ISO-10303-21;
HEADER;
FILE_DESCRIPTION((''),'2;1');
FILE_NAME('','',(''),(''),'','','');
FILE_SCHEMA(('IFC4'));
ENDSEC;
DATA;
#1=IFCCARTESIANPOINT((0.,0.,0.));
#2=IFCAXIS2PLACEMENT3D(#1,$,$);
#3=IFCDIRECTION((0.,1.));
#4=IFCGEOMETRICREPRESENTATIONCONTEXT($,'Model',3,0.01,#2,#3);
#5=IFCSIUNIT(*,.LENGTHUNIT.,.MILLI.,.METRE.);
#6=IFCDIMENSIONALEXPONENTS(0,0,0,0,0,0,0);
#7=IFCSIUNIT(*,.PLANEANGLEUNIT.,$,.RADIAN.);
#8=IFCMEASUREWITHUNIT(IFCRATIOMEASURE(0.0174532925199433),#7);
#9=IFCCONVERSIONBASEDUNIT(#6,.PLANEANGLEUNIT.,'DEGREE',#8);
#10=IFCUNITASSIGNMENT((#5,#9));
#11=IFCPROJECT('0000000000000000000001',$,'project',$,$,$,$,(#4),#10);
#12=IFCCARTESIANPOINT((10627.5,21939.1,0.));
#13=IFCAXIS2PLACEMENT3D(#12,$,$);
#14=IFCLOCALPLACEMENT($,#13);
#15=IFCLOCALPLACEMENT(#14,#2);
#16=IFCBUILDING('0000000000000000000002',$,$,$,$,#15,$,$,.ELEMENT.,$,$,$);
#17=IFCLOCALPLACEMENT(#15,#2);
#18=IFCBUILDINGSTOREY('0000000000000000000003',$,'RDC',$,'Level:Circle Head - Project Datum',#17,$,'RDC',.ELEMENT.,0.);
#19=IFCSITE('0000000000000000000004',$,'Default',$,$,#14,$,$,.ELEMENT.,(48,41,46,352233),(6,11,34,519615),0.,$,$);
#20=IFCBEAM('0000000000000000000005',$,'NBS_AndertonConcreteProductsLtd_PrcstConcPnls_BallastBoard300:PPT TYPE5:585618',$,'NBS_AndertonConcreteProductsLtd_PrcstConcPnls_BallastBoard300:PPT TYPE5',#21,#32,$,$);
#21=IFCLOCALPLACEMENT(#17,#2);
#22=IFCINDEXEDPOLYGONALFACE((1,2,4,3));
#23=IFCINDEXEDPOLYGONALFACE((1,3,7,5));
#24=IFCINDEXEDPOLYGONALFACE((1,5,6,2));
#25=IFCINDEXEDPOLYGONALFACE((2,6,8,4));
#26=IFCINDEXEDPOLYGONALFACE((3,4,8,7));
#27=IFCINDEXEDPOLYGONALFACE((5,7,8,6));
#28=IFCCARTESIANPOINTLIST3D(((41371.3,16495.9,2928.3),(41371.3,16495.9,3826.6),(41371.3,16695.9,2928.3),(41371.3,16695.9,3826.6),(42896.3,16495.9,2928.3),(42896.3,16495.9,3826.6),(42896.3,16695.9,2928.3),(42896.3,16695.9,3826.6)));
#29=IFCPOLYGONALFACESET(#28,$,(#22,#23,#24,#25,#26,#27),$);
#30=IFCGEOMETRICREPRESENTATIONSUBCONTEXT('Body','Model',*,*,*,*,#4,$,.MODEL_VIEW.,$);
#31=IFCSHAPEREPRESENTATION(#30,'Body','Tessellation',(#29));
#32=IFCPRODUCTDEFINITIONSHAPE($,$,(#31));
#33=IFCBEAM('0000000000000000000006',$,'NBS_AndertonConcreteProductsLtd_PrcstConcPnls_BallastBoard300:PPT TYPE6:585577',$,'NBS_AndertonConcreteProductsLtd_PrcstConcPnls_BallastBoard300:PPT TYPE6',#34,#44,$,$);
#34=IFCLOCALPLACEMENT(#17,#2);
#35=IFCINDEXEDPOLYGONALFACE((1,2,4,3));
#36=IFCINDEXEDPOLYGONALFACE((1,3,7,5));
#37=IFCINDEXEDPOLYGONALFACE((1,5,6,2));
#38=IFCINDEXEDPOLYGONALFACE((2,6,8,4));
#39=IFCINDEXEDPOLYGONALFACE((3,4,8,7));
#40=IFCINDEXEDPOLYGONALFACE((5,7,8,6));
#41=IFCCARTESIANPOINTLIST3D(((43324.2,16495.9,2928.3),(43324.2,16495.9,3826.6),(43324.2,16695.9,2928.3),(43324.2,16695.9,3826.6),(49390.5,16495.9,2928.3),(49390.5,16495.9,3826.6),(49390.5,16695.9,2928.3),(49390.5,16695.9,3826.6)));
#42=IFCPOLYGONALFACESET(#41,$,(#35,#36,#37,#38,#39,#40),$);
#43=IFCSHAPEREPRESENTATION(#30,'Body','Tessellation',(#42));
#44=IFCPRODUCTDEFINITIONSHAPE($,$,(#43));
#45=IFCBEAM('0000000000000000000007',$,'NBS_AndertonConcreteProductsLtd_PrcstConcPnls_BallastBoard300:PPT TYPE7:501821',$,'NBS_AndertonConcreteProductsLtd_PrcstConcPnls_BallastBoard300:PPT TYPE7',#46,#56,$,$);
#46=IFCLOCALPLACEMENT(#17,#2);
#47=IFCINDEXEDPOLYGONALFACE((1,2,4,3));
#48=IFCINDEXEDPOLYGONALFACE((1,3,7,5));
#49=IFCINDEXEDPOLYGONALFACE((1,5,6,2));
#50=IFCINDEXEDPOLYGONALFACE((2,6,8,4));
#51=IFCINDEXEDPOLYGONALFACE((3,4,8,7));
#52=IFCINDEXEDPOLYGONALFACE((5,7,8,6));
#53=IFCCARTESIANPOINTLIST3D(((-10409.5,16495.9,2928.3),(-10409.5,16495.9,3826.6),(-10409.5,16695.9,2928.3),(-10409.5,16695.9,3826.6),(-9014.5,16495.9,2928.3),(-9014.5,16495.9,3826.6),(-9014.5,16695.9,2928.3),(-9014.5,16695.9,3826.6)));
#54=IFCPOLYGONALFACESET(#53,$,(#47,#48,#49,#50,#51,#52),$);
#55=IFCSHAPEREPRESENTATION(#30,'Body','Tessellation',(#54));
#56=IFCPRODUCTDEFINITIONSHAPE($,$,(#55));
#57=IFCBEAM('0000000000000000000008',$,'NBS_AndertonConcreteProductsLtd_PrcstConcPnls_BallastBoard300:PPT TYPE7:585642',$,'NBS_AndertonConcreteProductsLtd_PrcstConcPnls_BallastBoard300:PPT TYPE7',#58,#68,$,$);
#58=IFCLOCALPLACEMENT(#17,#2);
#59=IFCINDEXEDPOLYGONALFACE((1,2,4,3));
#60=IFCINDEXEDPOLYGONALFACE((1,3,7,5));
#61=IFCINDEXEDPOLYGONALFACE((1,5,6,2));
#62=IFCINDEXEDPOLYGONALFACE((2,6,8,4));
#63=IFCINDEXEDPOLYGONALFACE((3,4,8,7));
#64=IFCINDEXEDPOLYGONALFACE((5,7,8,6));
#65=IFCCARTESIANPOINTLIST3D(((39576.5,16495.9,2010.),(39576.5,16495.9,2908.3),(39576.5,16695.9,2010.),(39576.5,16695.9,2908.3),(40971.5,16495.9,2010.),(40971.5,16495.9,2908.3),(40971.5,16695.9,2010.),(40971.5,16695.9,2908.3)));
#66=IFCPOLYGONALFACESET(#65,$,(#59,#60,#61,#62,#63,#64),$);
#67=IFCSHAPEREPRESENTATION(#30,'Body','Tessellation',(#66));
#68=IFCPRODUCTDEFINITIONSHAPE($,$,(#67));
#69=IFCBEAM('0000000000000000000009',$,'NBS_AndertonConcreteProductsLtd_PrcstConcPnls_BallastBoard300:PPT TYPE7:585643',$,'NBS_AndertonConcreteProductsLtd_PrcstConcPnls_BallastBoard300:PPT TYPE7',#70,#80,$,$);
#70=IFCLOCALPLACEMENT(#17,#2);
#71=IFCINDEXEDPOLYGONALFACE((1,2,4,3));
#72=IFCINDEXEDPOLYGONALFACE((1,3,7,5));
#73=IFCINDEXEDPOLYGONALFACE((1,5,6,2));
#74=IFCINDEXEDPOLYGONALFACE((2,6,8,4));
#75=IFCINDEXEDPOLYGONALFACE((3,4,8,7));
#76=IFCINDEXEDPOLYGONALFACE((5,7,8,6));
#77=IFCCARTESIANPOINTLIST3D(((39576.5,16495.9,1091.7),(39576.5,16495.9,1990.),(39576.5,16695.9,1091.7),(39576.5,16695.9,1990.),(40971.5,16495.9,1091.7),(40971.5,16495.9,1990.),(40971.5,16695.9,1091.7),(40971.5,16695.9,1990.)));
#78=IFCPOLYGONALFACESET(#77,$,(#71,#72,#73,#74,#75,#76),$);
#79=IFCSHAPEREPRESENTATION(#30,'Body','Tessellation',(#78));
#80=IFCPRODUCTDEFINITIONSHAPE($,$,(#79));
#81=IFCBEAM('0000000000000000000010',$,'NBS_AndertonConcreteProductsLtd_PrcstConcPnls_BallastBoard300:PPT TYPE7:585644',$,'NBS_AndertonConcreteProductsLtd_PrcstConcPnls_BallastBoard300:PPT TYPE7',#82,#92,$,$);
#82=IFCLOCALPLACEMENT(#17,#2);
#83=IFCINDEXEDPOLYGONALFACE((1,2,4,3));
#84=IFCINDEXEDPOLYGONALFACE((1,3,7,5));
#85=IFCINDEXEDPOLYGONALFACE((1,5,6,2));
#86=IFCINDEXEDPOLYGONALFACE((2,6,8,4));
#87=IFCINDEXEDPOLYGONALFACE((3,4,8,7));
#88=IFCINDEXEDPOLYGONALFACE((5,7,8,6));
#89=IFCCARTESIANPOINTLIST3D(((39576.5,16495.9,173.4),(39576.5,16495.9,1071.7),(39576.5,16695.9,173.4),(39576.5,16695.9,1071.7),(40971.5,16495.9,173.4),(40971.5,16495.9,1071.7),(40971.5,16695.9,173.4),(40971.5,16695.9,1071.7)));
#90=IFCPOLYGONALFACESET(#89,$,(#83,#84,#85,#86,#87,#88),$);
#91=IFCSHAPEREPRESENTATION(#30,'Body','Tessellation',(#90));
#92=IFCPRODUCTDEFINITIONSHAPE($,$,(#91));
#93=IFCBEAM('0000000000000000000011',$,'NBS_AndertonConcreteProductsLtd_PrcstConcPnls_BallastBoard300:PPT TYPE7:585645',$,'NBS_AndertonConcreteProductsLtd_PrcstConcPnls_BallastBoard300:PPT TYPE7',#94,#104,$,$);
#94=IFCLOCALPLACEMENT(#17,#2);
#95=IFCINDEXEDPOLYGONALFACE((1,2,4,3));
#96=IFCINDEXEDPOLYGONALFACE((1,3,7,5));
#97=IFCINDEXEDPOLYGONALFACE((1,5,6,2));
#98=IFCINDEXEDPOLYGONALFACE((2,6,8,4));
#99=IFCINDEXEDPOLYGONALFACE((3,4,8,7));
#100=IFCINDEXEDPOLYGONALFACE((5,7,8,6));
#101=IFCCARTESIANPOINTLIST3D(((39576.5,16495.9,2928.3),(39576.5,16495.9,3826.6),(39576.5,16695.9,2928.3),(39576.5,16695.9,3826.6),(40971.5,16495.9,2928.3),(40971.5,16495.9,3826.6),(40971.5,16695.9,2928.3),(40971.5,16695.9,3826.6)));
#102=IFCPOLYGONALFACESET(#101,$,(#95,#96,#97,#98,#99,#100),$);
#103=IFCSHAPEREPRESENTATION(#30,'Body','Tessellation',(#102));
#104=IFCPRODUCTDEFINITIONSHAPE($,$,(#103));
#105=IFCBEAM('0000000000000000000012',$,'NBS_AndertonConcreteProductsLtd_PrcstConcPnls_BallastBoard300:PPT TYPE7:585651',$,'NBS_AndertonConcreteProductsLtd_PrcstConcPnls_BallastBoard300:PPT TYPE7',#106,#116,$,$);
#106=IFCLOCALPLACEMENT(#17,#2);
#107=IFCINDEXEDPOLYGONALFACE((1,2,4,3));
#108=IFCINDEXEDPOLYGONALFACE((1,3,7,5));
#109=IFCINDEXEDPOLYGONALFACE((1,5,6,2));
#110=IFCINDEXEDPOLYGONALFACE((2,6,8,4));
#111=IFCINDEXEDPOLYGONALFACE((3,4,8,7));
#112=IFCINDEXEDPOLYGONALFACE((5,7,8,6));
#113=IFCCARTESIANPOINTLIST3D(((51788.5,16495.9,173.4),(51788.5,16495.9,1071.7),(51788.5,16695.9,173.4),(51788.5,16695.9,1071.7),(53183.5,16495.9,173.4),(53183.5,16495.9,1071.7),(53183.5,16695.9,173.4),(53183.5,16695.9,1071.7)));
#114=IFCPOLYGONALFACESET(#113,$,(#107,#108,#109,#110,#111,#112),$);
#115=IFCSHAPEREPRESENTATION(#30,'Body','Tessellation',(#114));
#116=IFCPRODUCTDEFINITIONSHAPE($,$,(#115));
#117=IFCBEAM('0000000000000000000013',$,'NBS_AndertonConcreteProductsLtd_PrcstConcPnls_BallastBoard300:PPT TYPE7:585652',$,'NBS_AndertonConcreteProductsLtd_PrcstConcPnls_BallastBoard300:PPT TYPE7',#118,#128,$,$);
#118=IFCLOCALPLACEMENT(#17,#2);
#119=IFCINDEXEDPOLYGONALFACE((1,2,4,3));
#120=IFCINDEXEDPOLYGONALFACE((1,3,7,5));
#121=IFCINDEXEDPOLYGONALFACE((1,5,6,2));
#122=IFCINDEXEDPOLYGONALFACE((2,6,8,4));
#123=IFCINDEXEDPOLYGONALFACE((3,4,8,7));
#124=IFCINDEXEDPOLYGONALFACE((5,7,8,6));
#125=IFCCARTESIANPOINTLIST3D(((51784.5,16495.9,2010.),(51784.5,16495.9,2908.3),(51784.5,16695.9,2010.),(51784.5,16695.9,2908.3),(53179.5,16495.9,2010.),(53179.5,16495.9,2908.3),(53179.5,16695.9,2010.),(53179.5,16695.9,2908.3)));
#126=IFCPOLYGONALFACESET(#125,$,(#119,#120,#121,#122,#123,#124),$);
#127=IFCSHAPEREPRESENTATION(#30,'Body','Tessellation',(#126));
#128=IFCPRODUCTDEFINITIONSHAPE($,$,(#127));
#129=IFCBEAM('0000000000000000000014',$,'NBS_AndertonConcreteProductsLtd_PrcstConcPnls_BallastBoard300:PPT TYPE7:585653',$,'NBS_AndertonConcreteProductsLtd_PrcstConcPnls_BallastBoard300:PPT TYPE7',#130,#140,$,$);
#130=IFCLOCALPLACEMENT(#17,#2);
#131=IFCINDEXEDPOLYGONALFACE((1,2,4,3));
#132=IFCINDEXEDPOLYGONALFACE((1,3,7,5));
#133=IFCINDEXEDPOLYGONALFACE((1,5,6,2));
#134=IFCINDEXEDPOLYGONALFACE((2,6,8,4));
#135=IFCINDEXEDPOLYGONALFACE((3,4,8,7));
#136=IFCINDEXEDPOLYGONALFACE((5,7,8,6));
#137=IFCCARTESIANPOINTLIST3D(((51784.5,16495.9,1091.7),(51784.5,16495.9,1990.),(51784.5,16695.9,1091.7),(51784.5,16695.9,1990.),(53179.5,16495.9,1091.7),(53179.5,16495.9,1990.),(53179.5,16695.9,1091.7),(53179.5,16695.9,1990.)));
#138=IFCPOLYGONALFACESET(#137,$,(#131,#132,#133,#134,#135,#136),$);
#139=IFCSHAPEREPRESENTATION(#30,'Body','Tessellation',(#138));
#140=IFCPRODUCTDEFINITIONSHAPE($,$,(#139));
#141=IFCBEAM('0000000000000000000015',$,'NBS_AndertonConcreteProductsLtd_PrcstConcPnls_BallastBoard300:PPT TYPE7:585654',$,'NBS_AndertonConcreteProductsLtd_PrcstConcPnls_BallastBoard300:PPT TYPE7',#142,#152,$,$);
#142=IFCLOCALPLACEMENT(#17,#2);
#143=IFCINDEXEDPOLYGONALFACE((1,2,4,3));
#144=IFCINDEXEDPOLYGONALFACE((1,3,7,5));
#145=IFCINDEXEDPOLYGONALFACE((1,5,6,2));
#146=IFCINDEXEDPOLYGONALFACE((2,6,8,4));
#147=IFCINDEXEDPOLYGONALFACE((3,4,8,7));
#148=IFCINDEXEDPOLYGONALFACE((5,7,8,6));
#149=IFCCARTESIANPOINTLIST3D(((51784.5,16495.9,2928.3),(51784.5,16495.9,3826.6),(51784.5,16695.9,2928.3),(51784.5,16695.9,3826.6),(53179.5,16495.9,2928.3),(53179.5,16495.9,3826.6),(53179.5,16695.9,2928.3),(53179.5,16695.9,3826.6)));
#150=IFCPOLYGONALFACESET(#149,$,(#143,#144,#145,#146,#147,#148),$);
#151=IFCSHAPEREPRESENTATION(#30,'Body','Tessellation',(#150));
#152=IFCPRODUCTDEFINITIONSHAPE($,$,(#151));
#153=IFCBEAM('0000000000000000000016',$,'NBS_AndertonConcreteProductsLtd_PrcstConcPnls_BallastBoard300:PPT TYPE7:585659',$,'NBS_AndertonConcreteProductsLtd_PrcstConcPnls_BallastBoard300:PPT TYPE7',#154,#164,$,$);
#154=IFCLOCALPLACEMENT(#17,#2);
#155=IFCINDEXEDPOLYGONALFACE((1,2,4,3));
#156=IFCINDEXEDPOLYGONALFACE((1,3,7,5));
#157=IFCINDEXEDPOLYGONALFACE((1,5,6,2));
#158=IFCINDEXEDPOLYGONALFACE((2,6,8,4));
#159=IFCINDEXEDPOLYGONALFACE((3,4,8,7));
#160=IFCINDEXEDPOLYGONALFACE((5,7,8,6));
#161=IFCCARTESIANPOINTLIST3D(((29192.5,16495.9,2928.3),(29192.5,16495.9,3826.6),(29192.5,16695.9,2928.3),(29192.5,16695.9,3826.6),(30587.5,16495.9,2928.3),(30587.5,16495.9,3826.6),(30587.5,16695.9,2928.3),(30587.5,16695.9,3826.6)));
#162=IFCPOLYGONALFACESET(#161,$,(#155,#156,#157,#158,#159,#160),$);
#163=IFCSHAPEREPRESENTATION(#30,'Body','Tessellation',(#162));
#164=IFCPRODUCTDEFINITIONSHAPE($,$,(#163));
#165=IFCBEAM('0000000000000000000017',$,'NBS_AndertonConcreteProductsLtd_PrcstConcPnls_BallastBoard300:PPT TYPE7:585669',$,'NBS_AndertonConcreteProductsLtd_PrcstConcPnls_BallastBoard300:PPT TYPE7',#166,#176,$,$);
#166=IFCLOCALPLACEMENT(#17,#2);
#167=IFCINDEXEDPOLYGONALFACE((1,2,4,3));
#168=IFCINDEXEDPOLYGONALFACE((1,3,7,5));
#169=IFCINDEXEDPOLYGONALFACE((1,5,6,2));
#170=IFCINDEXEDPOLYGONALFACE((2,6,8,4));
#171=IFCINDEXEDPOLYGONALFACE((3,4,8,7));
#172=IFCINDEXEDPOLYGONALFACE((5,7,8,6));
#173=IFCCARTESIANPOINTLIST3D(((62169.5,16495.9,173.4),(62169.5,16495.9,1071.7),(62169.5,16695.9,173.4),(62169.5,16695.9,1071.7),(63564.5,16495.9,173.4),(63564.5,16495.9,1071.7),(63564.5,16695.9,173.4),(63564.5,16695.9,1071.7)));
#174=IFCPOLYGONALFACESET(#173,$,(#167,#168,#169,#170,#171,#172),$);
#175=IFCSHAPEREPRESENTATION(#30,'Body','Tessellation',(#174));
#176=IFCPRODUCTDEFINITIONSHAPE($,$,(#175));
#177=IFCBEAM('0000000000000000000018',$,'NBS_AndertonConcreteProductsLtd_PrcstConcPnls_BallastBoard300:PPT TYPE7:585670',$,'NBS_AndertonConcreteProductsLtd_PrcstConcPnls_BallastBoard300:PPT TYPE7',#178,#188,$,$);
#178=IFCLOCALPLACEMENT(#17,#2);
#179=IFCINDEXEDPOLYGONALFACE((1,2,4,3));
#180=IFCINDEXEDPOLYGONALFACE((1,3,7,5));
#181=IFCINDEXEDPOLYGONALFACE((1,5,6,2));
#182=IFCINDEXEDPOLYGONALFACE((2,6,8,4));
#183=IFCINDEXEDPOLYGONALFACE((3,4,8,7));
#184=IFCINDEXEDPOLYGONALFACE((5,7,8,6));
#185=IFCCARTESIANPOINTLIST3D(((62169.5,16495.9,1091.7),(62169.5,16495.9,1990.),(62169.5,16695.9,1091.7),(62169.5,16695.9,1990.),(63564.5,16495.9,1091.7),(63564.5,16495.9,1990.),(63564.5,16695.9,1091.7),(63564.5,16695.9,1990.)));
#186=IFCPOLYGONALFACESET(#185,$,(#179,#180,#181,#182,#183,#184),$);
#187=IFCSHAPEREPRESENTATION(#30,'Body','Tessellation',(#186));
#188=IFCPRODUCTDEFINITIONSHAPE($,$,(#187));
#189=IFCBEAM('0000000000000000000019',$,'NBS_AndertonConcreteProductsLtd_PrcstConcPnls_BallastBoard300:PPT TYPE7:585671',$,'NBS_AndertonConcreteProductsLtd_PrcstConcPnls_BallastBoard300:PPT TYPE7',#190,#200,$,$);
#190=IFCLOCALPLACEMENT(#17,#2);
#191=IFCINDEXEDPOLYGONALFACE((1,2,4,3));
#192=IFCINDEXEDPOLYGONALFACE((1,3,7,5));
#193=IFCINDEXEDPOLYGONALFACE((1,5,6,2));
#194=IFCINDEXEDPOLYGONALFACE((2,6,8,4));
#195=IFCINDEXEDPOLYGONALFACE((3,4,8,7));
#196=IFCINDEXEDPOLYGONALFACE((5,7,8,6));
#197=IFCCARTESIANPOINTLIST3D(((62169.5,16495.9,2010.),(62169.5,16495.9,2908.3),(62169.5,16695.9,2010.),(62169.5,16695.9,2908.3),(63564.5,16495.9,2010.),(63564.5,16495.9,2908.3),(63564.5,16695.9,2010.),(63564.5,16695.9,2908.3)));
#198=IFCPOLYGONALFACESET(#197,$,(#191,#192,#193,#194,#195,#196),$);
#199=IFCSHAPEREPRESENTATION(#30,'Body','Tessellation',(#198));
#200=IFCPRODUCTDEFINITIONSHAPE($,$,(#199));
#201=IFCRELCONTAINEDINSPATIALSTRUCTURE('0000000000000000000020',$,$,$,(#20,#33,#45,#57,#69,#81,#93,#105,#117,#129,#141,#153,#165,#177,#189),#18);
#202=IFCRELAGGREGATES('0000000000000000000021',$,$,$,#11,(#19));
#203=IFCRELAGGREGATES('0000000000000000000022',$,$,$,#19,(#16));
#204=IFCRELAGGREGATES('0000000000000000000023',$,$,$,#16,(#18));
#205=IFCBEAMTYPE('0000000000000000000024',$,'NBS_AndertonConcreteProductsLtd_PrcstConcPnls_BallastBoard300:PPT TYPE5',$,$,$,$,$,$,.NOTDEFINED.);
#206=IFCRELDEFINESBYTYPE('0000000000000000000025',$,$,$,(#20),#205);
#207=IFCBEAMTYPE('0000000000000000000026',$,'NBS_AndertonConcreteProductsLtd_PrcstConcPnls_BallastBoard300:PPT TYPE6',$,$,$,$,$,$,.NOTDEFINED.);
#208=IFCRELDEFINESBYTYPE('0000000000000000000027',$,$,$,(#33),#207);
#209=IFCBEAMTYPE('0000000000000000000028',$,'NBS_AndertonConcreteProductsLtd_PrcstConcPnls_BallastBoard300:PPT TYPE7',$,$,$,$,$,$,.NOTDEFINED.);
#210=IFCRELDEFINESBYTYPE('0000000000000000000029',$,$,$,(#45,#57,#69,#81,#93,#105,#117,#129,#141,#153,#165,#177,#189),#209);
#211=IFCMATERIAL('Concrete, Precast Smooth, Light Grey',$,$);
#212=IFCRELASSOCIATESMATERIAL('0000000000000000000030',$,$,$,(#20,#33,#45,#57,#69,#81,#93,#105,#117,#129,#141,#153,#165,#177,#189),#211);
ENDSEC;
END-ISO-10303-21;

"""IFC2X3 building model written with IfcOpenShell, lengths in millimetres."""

from ifc_helpers import new_model, entity, si_unit, converted_unit, direction, frame, frame_2d, origin, place, context, subcontext, project, spatial, rectangle, extrude, material, type_object, element, save


model = new_model("IFC2X3")

# Units and contexts
model_context = context("Model", 3, precision=0.01, world=origin(), true_north=direction((0.0, 1.0)))
body_context = subcontext(model_context, "Body", "Model", "MODEL_VIEW")
ifc_project = project(units=[si_unit("LENGTHUNIT", "METRE", prefix="MILLI"), converted_unit("PLANEANGLEUNIT", "DEGREE", entity("IfcRatioMeasure", 0.0174532925199433), si_unit("PLANEANGLEUNIT", "RADIAN"), dimensions=[0, 0, 0, 0, 0, 0, 0])], contexts=[model_context])

# Site, building, storey
site_placement = place(None, frame((10627.5, 21939.1, 0.0)))
site = spatial("IfcSite", under=ifc_project, at=site_placement, Name="Default", CompositionType="ELEMENT", RefLatitude=(48, 41, 46, 352233), RefLongitude=(6, 11, 34, 519615), RefElevation=0.0)
building_placement = place(site_placement, origin())
building = spatial("IfcBuilding", under=site, at=building_placement, CompositionType="ELEMENT")
storey_placement = place(building_placement, origin())
storey = spatial("IfcBuildingStorey", under=building, at=storey_placement, Name="RDC", ObjectType="Level:Circle Head - Project Datum", LongName="RDC", CompositionType="ELEMENT", Elevation=0.0)

# Shared definitions
ifc_material = material(Name="Concrete, Precast Smooth, Light Grey")

# Beams
beam_type_1 = type_object("IfcBeamType", Name="NBS_AndertonConcreteProductsLtd_PrcstConcPnls_BallastBoard300:PPT TYPE5", PredefinedType="NOTDEFINED")
beam_1_placement = place(storey_placement, origin())
element("IfcBeam", 1, at=beam_1_placement, inside=storey, type_object=beam_type_1, material=ifc_material, Name="NBS_AndertonConcreteProductsLtd_PrcstConcPnls_BallastBoard300:PPT TYPE5:585618", ObjectType="NBS_AndertonConcreteProductsLtd_PrcstConcPnls_BallastBoard300:PPT TYPE5", context=body_context, shape_type="SweptSolid", body=[
    extrude(rectangle(XDim=898.3, YDim=200.0, at=frame_2d((0.0, 0.0), x_axis=(1.0, 0.0))), frame((41371.3, 16595.9, 3377.5), z_axis=(1.0, 0.0, 0.0), x_axis=(0.0, 0.0, -1.0)), (0.0, 0.0, 1.0), 1525.0),
])
beam_type_2 = type_object("IfcBeamType", Name="NBS_AndertonConcreteProductsLtd_PrcstConcPnls_BallastBoard300:PPT TYPE6", PredefinedType="NOTDEFINED")
beam_2_placement = place(storey_placement, origin())
element("IfcBeam", 2, at=beam_2_placement, inside=storey, type_object=beam_type_2, material=ifc_material, Name="NBS_AndertonConcreteProductsLtd_PrcstConcPnls_BallastBoard300:PPT TYPE6:585577", ObjectType="NBS_AndertonConcreteProductsLtd_PrcstConcPnls_BallastBoard300:PPT TYPE6", context=body_context, shape_type="SweptSolid", body=[
    extrude(rectangle(XDim=898.3, YDim=200.0, at=frame_2d((0.0, 0.0), x_axis=(1.0, 0.0))), frame((43324.2, 16595.9, 3377.5), z_axis=(1.0, 0.0, 0.0), x_axis=(0.0, 0.0, -1.0)), (0.0, 0.0, 1.0), 6066.3),
])
beam_type_3 = type_object("IfcBeamType", Name="NBS_AndertonConcreteProductsLtd_PrcstConcPnls_BallastBoard300:PPT TYPE7", PredefinedType="NOTDEFINED")
beam_3_placement = place(storey_placement, origin())
element("IfcBeam", 3, at=beam_3_placement, inside=storey, type_object=beam_type_3, material=ifc_material, Name="NBS_AndertonConcreteProductsLtd_PrcstConcPnls_BallastBoard300:PPT TYPE7:501821", ObjectType="NBS_AndertonConcreteProductsLtd_PrcstConcPnls_BallastBoard300:PPT TYPE7", context=body_context, shape_type="SweptSolid", body=[
    extrude(rectangle(XDim=898.3, YDim=200.0, at=frame_2d((0.0, 0.0), x_axis=(0.0, 1.0))), frame((-10409.5, 16595.9, 3377.4), z_axis=(1.0, 0.0, 0.0), x_axis=(0.0, 1.0, 0.0)), (0.0, 0.0, 1.0), 1395.0),
])
beam_4_placement = place(storey_placement, origin())
element("IfcBeam", 4, at=beam_4_placement, inside=storey, type_object=beam_type_3, material=ifc_material, Name="NBS_AndertonConcreteProductsLtd_PrcstConcPnls_BallastBoard300:PPT TYPE7:585642", ObjectType="NBS_AndertonConcreteProductsLtd_PrcstConcPnls_BallastBoard300:PPT TYPE7", context=body_context, shape_type="SweptSolid", body=[
    extrude(rectangle(XDim=898.3, YDim=200.0, at=frame_2d((0.0, 0.0), x_axis=(1.0, 0.0))), frame((39576.5, 16595.9, 2459.2), z_axis=(1.0, 0.0, 0.0), x_axis=(0.0, 0.0, -1.0)), (0.0, 0.0, 1.0), 1395.0),
])
beam_5_placement = place(storey_placement, origin())
element("IfcBeam", 5, at=beam_5_placement, inside=storey, type_object=beam_type_3, material=ifc_material, Name="NBS_AndertonConcreteProductsLtd_PrcstConcPnls_BallastBoard300:PPT TYPE7:585643", ObjectType="NBS_AndertonConcreteProductsLtd_PrcstConcPnls_BallastBoard300:PPT TYPE7", context=body_context, shape_type="SweptSolid", body=[
    extrude(rectangle(XDim=898.3, YDim=200.0, at=frame_2d((0.0, 0.0), x_axis=(1.0, 0.0))), frame((39576.5, 16595.9, 1540.8), z_axis=(1.0, 0.0, 0.0), x_axis=(0.0, 0.0, -1.0)), (0.0, 0.0, 1.0), 1395.0),
])
beam_6_placement = place(storey_placement, origin())
element("IfcBeam", 6, at=beam_6_placement, inside=storey, type_object=beam_type_3, material=ifc_material, Name="NBS_AndertonConcreteProductsLtd_PrcstConcPnls_BallastBoard300:PPT TYPE7:585644", ObjectType="NBS_AndertonConcreteProductsLtd_PrcstConcPnls_BallastBoard300:PPT TYPE7", context=body_context, shape_type="SweptSolid", body=[
    extrude(rectangle(XDim=898.3, YDim=200.0, at=frame_2d((0.0, 0.0), x_axis=(1.0, 0.0))), frame((39576.5, 16595.9, 622.5), z_axis=(1.0, 0.0, 0.0), x_axis=(0.0, 0.0, -1.0)), (0.0, 0.0, 1.0), 1395.0),
])
beam_7_placement = place(storey_placement, origin())
element("IfcBeam", 7, at=beam_7_placement, inside=storey, type_object=beam_type_3, material=ifc_material, Name="NBS_AndertonConcreteProductsLtd_PrcstConcPnls_BallastBoard300:PPT TYPE7:585645", ObjectType="NBS_AndertonConcreteProductsLtd_PrcstConcPnls_BallastBoard300:PPT TYPE7", context=body_context, shape_type="SweptSolid", body=[
    extrude(rectangle(XDim=898.3, YDim=200.0, at=frame_2d((0.0, 0.0), x_axis=(1.0, 0.0))), frame((39576.5, 16595.9, 3377.5), z_axis=(1.0, 0.0, 0.0), x_axis=(0.0, 0.0, -1.0)), (0.0, 0.0, 1.0), 1395.0),
])
beam_8_placement = place(storey_placement, origin())
element("IfcBeam", 8, at=beam_8_placement, inside=storey, type_object=beam_type_3, material=ifc_material, Name="NBS_AndertonConcreteProductsLtd_PrcstConcPnls_BallastBoard300:PPT TYPE7:585651", ObjectType="NBS_AndertonConcreteProductsLtd_PrcstConcPnls_BallastBoard300:PPT TYPE7", context=body_context, shape_type="SweptSolid", body=[
    extrude(rectangle(XDim=898.3, YDim=200.0, at=frame_2d((0.0, 0.0), x_axis=(1.0, 0.0))), frame((51788.5, 16595.9, 622.5), z_axis=(1.0, 0.0, 0.0), x_axis=(0.0, 0.0, -1.0)), (0.0, 0.0, 1.0), 1395.0),
])
beam_9_placement = place(storey_placement, origin())
element("IfcBeam", 9, at=beam_9_placement, inside=storey, type_object=beam_type_3, material=ifc_material, Name="NBS_AndertonConcreteProductsLtd_PrcstConcPnls_BallastBoard300:PPT TYPE7:585652", ObjectType="NBS_AndertonConcreteProductsLtd_PrcstConcPnls_BallastBoard300:PPT TYPE7", context=body_context, shape_type="SweptSolid", body=[
    extrude(rectangle(XDim=898.3, YDim=200.0, at=frame_2d((0.0, 0.0), x_axis=(1.0, 0.0))), frame((51784.5, 16595.9, 2459.2), z_axis=(1.0, 0.0, 0.0), x_axis=(0.0, 0.0, -1.0)), (0.0, 0.0, 1.0), 1395.0),
])
beam_10_placement = place(storey_placement, origin())
element("IfcBeam", 10, at=beam_10_placement, inside=storey, type_object=beam_type_3, material=ifc_material, Name="NBS_AndertonConcreteProductsLtd_PrcstConcPnls_BallastBoard300:PPT TYPE7:585653", ObjectType="NBS_AndertonConcreteProductsLtd_PrcstConcPnls_BallastBoard300:PPT TYPE7", context=body_context, shape_type="SweptSolid", body=[
    extrude(rectangle(XDim=898.3, YDim=200.0, at=frame_2d((0.0, 0.0), x_axis=(1.0, 0.0))), frame((51784.5, 16595.9, 1540.8), z_axis=(1.0, 0.0, 0.0), x_axis=(0.0, 0.0, -1.0)), (0.0, 0.0, 1.0), 1395.0),
])
beam_11_placement = place(storey_placement, origin())
element("IfcBeam", 11, at=beam_11_placement, inside=storey, type_object=beam_type_3, material=ifc_material, Name="NBS_AndertonConcreteProductsLtd_PrcstConcPnls_BallastBoard300:PPT TYPE7:585654", ObjectType="NBS_AndertonConcreteProductsLtd_PrcstConcPnls_BallastBoard300:PPT TYPE7", context=body_context, shape_type="SweptSolid", body=[
    extrude(rectangle(XDim=898.3, YDim=200.0, at=frame_2d((0.0, 0.0), x_axis=(1.0, 0.0))), frame((51784.5, 16595.9, 3377.5), z_axis=(1.0, 0.0, 0.0), x_axis=(0.0, 0.0, -1.0)), (0.0, 0.0, 1.0), 1395.0),
])
beam_12_placement = place(storey_placement, origin())
element("IfcBeam", 12, at=beam_12_placement, inside=storey, type_object=beam_type_3, material=ifc_material, Name="NBS_AndertonConcreteProductsLtd_PrcstConcPnls_BallastBoard300:PPT TYPE7:585659", ObjectType="NBS_AndertonConcreteProductsLtd_PrcstConcPnls_BallastBoard300:PPT TYPE7", context=body_context, shape_type="SweptSolid", body=[
    extrude(rectangle(XDim=898.3, YDim=200.0, at=frame_2d((0.0, 0.0), x_axis=(1.0, 0.0))), frame((29192.5, 16595.9, 3377.5), z_axis=(1.0, 0.0, 0.0), x_axis=(0.0, 0.0, -1.0)), (0.0, 0.0, 1.0), 1395.0),
])
beam_13_placement = place(storey_placement, origin())
element("IfcBeam", 13, at=beam_13_placement, inside=storey, type_object=beam_type_3, material=ifc_material, Name="NBS_AndertonConcreteProductsLtd_PrcstConcPnls_BallastBoard300:PPT TYPE7:585669", ObjectType="NBS_AndertonConcreteProductsLtd_PrcstConcPnls_BallastBoard300:PPT TYPE7", context=body_context, shape_type="SweptSolid", body=[
    extrude(rectangle(XDim=898.3, YDim=200.0, at=frame_2d((0.0, 0.0), x_axis=(1.0, 0.0))), frame((62169.5, 16595.9, 622.5), z_axis=(1.0, 0.0, 0.0), x_axis=(0.0, 0.0, -1.0)), (0.0, 0.0, 1.0), 1395.0),
])
beam_14_placement = place(storey_placement, origin())
element("IfcBeam", 14, at=beam_14_placement, inside=storey, type_object=beam_type_3, material=ifc_material, Name="NBS_AndertonConcreteProductsLtd_PrcstConcPnls_BallastBoard300:PPT TYPE7:585670", ObjectType="NBS_AndertonConcreteProductsLtd_PrcstConcPnls_BallastBoard300:PPT TYPE7", context=body_context, shape_type="SweptSolid", body=[
    extrude(rectangle(XDim=898.3, YDim=200.0, at=frame_2d((0.0, 0.0), x_axis=(1.0, 0.0))), frame((62169.5, 16595.9, 1540.8), z_axis=(1.0, 0.0, 0.0), x_axis=(0.0, 0.0, -1.0)), (0.0, 0.0, 1.0), 1395.0),
])
beam_15_placement = place(storey_placement, origin())
element("IfcBeam", 15, at=beam_15_placement, inside=storey, type_object=beam_type_3, material=ifc_material, Name="NBS_AndertonConcreteProductsLtd_PrcstConcPnls_BallastBoard300:PPT TYPE7:585671", ObjectType="NBS_AndertonConcreteProductsLtd_PrcstConcPnls_BallastBoard300:PPT TYPE7", context=body_context, shape_type="SweptSolid", body=[
    extrude(rectangle(XDim=898.3, YDim=200.0, at=frame_2d((0.0, 0.0), x_axis=(1.0, 0.0))), frame((62169.5, 16595.9, 2459.1), z_axis=(1.0, 0.0, 0.0), x_axis=(0.0, 0.0, -1.0)), (0.0, 0.0, 1.0), 1395.0),
])

save(model, "model.ifc")
